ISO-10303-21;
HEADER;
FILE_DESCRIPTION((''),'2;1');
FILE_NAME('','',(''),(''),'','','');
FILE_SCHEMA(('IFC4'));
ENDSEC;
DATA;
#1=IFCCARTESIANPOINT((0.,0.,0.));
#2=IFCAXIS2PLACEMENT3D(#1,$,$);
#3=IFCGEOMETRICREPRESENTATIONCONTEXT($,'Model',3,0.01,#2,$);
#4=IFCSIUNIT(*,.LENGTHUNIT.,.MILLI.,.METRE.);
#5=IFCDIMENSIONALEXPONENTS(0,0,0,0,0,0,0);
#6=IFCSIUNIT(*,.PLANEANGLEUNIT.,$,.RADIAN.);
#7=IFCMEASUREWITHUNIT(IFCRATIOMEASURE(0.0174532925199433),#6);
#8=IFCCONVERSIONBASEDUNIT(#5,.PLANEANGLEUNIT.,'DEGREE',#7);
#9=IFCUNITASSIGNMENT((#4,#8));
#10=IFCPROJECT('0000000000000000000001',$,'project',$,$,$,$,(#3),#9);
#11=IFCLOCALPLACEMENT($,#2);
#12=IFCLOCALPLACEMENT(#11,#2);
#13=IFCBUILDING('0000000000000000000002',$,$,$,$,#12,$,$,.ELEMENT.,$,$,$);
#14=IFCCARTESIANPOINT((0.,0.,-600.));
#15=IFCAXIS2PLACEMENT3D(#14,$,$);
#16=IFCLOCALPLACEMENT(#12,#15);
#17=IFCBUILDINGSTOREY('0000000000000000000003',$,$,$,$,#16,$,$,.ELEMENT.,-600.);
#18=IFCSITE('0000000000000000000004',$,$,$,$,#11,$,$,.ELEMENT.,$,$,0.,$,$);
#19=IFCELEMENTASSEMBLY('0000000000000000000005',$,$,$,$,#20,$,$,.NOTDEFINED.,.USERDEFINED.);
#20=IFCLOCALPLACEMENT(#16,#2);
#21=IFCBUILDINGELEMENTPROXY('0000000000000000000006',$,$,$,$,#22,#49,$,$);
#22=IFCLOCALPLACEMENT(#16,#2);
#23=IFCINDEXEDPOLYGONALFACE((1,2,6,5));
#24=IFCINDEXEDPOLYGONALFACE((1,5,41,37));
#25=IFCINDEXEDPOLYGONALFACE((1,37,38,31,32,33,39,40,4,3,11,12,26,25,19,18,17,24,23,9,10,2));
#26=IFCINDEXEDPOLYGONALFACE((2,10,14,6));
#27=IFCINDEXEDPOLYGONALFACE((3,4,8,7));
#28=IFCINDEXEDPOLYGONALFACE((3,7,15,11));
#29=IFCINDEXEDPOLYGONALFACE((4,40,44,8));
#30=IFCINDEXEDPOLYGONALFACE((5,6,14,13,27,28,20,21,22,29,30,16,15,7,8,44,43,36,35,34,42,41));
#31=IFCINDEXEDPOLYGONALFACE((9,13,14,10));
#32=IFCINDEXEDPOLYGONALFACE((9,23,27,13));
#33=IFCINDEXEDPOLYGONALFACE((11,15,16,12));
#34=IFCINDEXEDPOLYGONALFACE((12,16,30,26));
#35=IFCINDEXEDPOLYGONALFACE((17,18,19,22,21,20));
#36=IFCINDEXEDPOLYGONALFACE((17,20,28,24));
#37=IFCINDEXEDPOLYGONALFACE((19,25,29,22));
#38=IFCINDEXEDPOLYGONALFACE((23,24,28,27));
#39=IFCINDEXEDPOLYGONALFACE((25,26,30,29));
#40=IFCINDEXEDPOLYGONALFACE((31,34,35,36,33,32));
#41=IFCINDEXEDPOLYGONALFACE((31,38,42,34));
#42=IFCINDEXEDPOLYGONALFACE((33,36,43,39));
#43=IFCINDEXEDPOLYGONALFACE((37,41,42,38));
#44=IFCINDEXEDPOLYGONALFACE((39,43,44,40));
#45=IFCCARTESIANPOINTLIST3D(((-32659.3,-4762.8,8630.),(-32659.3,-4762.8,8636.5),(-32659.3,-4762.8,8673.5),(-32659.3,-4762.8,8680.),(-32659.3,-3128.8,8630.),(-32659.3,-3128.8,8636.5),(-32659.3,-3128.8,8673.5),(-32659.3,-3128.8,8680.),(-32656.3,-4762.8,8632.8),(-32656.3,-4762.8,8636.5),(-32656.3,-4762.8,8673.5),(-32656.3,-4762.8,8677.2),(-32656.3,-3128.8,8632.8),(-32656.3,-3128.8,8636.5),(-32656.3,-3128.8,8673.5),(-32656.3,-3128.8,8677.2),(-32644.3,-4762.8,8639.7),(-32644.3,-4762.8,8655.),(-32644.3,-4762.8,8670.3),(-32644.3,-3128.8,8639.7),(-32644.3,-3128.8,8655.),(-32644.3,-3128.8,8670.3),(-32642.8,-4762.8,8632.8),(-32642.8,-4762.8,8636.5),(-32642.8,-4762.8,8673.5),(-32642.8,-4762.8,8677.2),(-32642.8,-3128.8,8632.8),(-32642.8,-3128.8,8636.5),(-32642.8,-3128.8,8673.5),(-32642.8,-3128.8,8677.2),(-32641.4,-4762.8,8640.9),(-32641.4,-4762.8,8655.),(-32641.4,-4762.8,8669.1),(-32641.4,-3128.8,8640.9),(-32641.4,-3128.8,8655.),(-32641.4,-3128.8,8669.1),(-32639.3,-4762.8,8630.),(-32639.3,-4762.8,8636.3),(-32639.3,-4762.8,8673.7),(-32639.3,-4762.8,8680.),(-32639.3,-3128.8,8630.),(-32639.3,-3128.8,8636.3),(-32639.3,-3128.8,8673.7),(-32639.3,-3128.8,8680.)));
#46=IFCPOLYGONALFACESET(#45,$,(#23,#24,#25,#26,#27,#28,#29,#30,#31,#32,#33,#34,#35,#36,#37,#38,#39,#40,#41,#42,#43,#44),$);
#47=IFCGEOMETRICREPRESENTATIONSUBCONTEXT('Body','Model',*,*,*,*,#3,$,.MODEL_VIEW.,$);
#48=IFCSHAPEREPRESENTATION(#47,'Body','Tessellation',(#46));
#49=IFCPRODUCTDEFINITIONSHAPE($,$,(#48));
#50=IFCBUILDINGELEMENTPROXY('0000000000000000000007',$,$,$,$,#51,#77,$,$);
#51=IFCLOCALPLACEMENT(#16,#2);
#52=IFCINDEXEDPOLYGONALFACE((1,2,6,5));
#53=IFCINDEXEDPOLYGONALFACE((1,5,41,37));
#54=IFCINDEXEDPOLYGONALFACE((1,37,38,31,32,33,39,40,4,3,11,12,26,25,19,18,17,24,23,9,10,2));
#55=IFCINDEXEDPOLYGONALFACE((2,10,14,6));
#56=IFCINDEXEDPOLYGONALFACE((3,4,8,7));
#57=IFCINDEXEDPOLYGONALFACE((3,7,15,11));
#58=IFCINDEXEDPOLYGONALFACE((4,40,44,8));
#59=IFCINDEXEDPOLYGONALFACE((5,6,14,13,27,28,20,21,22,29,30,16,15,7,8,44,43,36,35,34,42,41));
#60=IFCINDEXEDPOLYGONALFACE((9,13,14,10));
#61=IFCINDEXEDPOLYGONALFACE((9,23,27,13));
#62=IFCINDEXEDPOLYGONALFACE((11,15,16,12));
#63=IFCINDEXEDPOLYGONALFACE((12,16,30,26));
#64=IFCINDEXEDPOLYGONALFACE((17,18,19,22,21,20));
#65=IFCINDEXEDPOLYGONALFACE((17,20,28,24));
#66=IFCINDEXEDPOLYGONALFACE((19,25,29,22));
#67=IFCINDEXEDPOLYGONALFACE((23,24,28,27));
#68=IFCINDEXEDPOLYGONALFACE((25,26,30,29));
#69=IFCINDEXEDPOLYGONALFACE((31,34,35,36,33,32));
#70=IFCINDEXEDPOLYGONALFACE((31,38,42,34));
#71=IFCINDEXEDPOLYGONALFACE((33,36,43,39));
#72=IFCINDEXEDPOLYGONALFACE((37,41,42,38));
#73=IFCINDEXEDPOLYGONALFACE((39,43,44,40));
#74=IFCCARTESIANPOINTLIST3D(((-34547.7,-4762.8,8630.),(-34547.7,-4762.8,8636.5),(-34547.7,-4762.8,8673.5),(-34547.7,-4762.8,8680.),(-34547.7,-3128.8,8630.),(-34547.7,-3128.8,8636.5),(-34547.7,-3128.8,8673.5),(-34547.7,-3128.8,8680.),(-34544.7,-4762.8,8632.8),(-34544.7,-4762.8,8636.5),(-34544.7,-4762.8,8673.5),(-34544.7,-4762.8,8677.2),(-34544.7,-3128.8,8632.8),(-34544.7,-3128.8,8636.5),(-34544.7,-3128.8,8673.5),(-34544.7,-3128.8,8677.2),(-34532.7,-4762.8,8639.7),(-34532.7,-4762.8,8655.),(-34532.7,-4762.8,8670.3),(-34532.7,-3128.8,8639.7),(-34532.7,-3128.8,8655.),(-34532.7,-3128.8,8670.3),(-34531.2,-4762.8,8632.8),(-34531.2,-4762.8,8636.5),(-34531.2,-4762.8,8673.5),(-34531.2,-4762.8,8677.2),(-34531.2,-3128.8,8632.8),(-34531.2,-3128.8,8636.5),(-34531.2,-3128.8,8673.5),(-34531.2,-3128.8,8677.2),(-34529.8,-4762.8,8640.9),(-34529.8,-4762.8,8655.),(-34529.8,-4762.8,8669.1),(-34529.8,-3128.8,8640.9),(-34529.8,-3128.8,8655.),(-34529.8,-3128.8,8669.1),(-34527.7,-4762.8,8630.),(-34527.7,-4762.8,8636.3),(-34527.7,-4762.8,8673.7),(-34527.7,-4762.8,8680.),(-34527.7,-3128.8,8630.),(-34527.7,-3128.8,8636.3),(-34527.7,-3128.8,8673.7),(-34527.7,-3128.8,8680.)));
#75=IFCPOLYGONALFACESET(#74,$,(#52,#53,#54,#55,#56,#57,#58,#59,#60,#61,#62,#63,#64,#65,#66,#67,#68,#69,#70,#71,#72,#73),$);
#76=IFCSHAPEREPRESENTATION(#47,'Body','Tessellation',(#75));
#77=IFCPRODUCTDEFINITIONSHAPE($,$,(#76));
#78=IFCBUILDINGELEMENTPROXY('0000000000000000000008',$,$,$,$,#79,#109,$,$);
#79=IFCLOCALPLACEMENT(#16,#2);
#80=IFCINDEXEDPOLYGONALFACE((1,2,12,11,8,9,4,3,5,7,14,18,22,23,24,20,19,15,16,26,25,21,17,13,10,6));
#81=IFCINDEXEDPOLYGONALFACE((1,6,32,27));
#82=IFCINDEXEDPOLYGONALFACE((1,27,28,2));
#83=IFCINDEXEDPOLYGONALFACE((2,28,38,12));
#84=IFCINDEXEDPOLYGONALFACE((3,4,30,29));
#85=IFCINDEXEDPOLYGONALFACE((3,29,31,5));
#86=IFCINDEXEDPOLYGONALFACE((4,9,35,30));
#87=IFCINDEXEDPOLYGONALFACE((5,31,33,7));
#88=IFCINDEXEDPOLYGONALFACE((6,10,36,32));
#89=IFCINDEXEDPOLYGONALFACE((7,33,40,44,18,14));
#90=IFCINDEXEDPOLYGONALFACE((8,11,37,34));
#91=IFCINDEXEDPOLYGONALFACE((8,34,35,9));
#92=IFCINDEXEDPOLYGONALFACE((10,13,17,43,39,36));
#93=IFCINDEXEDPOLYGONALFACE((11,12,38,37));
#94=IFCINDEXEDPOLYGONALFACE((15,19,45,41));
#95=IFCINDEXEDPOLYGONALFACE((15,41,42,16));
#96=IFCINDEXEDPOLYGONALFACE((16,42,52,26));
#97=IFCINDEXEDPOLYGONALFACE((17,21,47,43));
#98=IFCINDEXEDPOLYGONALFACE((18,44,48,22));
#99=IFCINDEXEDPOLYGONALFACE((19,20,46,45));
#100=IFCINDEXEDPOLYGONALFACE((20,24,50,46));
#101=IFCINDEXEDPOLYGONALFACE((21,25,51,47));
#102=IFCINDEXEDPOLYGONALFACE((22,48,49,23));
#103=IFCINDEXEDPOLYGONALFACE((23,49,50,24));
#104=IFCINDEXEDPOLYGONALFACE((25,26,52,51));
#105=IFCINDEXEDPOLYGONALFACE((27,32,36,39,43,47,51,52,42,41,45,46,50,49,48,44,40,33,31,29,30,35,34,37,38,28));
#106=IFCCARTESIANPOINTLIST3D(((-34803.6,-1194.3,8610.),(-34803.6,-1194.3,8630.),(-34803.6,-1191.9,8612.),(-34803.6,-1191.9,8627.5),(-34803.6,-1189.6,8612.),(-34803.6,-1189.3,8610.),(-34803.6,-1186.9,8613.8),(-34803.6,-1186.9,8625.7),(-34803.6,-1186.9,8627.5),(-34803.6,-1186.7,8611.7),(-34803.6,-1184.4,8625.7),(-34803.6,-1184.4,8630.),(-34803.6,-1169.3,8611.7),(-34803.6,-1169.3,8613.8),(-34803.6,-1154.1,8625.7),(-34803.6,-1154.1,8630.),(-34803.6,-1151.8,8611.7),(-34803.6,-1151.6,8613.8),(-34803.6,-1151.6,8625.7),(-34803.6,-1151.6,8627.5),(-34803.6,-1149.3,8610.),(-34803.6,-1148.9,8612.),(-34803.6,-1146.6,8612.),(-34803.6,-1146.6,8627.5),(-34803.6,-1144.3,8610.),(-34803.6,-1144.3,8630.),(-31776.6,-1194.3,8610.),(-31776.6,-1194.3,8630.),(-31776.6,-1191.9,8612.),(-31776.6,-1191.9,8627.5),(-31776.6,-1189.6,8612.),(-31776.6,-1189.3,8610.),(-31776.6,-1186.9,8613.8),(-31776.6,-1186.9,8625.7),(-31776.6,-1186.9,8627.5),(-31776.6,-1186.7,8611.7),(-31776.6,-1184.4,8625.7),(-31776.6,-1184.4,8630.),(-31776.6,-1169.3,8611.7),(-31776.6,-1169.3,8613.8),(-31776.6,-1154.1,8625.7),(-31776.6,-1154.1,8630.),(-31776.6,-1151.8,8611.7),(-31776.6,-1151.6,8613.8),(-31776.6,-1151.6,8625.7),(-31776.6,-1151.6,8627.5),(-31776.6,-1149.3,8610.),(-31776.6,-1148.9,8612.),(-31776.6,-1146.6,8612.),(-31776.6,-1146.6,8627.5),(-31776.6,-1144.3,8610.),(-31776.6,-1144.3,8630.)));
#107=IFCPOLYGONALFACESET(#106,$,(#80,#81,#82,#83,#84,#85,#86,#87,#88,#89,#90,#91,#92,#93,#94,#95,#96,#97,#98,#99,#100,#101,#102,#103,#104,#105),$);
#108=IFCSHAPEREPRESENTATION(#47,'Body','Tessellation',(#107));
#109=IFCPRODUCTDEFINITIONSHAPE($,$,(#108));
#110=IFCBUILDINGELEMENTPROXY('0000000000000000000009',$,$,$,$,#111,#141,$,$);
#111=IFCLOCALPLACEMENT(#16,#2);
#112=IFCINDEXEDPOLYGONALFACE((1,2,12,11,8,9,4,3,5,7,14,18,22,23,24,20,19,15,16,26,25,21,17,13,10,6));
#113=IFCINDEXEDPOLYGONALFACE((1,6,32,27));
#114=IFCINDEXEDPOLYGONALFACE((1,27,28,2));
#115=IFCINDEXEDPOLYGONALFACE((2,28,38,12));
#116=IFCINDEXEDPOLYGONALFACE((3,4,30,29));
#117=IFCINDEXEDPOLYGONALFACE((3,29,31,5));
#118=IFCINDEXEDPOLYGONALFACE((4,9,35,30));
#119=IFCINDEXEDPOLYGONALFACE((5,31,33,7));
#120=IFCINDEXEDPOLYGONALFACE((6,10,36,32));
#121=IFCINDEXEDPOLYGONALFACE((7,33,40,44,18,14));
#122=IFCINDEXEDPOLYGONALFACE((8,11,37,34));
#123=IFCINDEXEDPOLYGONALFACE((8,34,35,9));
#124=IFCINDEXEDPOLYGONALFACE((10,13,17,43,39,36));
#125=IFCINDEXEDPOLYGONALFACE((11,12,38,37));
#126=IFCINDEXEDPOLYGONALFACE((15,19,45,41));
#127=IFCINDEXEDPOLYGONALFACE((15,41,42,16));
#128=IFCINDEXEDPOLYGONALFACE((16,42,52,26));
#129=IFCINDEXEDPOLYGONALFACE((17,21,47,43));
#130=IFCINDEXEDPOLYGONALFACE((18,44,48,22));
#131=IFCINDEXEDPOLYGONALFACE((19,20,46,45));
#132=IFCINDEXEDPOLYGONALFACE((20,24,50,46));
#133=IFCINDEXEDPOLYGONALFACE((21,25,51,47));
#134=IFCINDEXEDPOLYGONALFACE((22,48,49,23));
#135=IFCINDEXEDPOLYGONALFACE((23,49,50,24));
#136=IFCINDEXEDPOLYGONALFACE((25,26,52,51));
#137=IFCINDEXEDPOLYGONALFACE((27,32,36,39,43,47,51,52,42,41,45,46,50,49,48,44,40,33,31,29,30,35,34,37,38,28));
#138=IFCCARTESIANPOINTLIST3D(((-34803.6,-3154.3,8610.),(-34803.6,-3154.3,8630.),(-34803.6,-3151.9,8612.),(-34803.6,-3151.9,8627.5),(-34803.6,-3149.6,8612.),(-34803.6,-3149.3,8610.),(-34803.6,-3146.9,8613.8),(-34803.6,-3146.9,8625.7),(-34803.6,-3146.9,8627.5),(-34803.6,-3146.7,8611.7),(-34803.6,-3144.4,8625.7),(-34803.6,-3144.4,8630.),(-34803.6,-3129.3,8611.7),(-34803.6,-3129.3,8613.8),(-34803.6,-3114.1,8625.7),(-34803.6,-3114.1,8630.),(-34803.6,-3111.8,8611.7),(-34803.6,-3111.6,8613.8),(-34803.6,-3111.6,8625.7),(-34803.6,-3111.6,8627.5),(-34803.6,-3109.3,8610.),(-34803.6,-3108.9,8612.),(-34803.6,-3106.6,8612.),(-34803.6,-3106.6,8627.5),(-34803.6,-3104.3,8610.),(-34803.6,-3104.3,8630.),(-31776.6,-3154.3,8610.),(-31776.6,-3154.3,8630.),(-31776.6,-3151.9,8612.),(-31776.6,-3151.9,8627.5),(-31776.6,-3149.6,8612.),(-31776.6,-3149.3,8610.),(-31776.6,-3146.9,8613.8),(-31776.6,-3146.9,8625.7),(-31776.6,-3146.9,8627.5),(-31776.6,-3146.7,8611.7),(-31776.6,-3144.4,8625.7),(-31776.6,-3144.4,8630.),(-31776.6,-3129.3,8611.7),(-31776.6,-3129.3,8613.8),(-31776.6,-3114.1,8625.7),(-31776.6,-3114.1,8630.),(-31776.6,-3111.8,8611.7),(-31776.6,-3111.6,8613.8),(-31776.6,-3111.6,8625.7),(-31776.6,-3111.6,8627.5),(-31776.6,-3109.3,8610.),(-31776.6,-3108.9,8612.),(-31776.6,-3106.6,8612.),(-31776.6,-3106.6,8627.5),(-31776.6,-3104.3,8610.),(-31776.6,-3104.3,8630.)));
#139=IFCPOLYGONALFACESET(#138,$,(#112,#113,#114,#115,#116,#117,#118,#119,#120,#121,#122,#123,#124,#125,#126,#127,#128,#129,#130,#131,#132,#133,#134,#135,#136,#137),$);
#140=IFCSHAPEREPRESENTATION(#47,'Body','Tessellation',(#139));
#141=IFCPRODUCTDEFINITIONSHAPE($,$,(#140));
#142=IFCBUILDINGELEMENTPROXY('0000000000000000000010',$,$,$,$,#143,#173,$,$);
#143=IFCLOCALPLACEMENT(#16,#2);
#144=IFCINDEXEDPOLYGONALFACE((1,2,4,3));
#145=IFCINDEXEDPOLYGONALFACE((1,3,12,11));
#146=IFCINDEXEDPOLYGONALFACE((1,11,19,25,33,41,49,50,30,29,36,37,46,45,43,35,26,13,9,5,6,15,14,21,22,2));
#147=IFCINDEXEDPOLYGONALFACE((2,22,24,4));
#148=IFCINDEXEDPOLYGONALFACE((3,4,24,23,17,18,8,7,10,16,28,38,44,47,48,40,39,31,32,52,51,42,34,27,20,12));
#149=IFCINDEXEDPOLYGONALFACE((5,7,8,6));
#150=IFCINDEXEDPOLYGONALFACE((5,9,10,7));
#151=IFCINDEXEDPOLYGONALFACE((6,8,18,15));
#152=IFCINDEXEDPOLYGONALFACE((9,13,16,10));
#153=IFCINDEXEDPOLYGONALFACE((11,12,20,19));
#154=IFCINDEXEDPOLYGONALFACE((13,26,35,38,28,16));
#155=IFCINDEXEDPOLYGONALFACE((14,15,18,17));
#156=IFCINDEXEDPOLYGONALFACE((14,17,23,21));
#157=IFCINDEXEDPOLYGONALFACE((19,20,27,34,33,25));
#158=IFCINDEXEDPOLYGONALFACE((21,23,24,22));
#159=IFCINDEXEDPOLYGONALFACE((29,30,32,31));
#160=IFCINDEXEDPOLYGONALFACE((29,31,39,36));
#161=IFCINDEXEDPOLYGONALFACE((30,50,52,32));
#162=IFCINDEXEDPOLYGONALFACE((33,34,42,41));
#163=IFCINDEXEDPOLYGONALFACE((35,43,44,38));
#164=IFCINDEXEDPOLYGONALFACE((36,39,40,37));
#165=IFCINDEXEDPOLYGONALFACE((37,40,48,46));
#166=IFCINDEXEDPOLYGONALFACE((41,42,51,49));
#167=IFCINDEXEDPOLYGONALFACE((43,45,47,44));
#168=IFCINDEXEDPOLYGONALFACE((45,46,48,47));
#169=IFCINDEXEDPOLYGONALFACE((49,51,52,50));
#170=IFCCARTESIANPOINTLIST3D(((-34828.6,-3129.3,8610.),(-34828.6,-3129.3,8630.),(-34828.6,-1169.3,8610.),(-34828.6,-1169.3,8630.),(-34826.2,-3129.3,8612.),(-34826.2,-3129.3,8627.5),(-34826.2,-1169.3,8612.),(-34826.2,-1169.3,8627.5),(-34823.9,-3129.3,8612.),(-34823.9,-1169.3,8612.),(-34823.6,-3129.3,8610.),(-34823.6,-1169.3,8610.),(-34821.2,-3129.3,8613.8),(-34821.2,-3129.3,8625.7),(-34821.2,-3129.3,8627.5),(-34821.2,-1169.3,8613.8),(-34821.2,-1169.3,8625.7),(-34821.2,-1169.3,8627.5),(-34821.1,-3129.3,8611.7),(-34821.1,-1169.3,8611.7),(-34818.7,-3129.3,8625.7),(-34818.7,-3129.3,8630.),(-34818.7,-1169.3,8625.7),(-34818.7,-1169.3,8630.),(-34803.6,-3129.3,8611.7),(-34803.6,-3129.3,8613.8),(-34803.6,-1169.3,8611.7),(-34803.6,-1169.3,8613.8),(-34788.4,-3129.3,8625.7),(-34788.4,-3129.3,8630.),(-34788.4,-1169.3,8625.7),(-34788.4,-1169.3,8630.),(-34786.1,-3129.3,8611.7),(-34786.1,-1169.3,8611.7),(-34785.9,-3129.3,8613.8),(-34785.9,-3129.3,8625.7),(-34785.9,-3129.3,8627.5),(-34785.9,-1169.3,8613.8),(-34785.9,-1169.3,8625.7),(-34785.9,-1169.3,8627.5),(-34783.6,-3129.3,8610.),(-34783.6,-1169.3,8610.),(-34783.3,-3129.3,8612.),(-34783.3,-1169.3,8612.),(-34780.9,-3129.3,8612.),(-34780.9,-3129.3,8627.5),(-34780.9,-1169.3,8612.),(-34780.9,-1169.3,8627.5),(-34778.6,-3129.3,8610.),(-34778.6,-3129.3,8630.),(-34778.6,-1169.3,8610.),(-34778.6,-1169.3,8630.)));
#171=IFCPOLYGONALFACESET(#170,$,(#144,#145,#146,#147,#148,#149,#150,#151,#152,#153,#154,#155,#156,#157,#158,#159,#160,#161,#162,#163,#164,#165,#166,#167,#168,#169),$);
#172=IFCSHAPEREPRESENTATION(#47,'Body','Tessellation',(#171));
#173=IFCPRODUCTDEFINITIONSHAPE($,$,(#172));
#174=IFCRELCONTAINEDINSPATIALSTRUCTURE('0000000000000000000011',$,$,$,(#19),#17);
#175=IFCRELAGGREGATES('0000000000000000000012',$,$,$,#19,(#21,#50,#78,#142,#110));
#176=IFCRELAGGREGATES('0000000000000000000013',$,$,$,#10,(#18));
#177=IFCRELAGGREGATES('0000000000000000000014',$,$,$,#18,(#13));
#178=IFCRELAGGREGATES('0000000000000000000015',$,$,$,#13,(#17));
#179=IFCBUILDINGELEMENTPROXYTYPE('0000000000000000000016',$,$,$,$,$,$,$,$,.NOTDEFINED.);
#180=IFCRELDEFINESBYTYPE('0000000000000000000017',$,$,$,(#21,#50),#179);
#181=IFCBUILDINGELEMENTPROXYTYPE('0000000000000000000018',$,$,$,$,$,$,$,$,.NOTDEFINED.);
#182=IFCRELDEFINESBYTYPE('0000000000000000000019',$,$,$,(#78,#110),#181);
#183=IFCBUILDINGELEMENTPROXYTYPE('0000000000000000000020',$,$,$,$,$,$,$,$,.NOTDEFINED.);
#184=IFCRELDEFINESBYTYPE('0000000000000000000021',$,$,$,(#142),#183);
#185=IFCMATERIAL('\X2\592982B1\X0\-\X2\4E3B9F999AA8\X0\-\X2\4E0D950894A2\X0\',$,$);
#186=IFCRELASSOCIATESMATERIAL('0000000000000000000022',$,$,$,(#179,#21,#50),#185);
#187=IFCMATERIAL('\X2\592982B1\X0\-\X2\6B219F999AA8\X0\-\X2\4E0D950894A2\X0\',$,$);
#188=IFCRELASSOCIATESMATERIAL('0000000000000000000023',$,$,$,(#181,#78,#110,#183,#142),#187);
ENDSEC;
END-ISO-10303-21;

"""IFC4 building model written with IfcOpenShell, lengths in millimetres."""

from ifc_helpers import new_model, entity, si_unit, converted_unit, frame, origin, place, context, subcontext, project, spatial, polyline, outline, extrude, source, transform, mapped, material, type_object, type_shapes, element, aggregate, save


model = new_model("IFC4")

# Units and contexts
model_context = context("Model", 3, precision=0.01, world=origin())
body_context = subcontext(model_context, "Body", "Model", "MODEL_VIEW")
ifc_project = project(units=[si_unit("LENGTHUNIT", "METRE", prefix="MILLI"), converted_unit("PLANEANGLEUNIT", "DEGREE", entity("IfcRatioMeasure", 0.0174532925199433), si_unit("PLANEANGLEUNIT", "RADIAN"), dimensions=[0, 0, 0, 0, 0, 0, 0])], contexts=[model_context])

# Site, building, storey
site_placement = place(None, origin())
site = spatial("IfcSite", under=ifc_project, at=site_placement, CompositionType="ELEMENT", RefElevation=0.0)
building_placement = place(site_placement, origin())
building = spatial("IfcBuilding", under=site, at=building_placement, CompositionType="ELEMENT")
storey_placement = place(building_placement, frame((0.0, 0.0, -600.0)))
storey = spatial("IfcBuildingStorey", under=building, at=storey_placement, CompositionType="ELEMENT", Elevation=-600.0)

# Element assembly, building element proxies
assembly_placement = place(storey_placement, origin())
assembly = element("IfcElementAssembly", 1, at=assembly_placement, inside=storey, AssemblyPlace="NOTDEFINED", PredefinedType="USERDEFINED")
ifc_material_1 = material(Name="天花-次龙骨-不锈钢")
ifc_material_2 = material(Name="天花-主龙骨-不锈钢")
building_element_proxy_type_1 = type_object("IfcBuildingElementProxyType", PredefinedType="NOTDEFINED", material=ifc_material_2)
shared_shape_1 = source(origin(), body_context, "Body", "SweptSolid", [
    extrude(outline(polyline([(-25.0, -11.7), (-18.5, -11.7), (-18.5, -8.7), (-22.2, -8.7), (-22.2, 4.8), (-18.5, 4.8), (-15.3, 3.3), (0.0, 3.3), (15.3, 3.3), (18.5, 4.8), (22.2, 4.8), (22.2, -8.7), (18.5, -8.7), (18.5, -11.7), (25.0, -11.7), (25.0, 8.3), (18.7, 8.3), (14.1, 6.2), (0.0, 6.2), (-14.1, 6.2), (-18.7, 8.3), (-25.0, 8.3), (-25.0, -11.7)])), frame((0.0, 1.7, 0.0), z_axis=(1.0, 0.0, 0.0), x_axis=(0.0, 0.0, -1.0)), (0.0, 0.0, 1.0), 1634.0),
])
type_shapes(building_element_proxy_type_1, [shared_shape_1])
proxy_1_placement = place(assembly_placement, frame((-32649.3, -3128.8, 8655.0), z_axis=(0.0, 0.0, 1.0), x_axis=(0.0, -1.0, 0.0)))
proxy_1 = element("IfcBuildingElementProxy", 2, at=proxy_1_placement, type_object=building_element_proxy_type_1, material=ifc_material_2, context=body_context, shape_type="MappedRepresentation", body=[
    mapped(shared_shape_1, transform((0.0, 0.0, 0.0), scale=1.0)),
])
proxy_2_placement = place(assembly_placement, frame((-34537.7, -3128.8, 8655.0), z_axis=(0.0, 0.0, 1.0), x_axis=(0.0, -1.0, 0.0)))
proxy_2 = element("IfcBuildingElementProxy", 3, at=proxy_2_placement, type_object=building_element_proxy_type_1, material=ifc_material_2, context=body_context, shape_type="MappedRepresentation", body=[
    mapped(shared_shape_1, transform((0.0, 0.0, 0.0), scale=1.0)),
])
building_element_proxy_type_2 = type_object("IfcBuildingElementProxyType", PredefinedType="NOTDEFINED", material=ifc_material_1)
shared_shape_2 = source(origin(), body_context, "Body", "SweptSolid", [
    extrude(outline(polyline([(-25.0, -9.1), (-20.0, -9.1), (-17.5, -7.4), (0.0, -7.4), (17.5, -7.4), (20.0, -9.1), (25.0, -9.1), (25.0, 10.9), (15.1, 10.9), (15.1, 6.6), (17.6, 6.6), (17.6, 8.4), (22.6, 8.4), (22.6, -7.1), (20.3, -7.1), (17.6, -5.3), (0.0, -5.3), (-17.6, -5.3), (-20.3, -7.1), (-22.6, -7.1), (-22.6, 8.4), (-17.6, 8.4), (-17.6, 6.6), (-15.1, 6.6), (-15.1, 10.9), (-25.0, 10.9), (-25.0, -9.1)])), frame((0.0, 0.0, -0.9), z_axis=(1.0, 0.0, 0.0), x_axis=(0.0, 1.0, 0.0)), (0.0, 0.0, 1.0), 3027.0),
])
type_shapes(building_element_proxy_type_2, [shared_shape_2])
proxy_3_placement = place(assembly_placement, frame((-34803.6, -1169.3, 8620.0)))
proxy_3 = element("IfcBuildingElementProxy", 4, at=proxy_3_placement, type_object=building_element_proxy_type_2, material=ifc_material_1, context=body_context, shape_type="MappedRepresentation", body=[
    mapped(shared_shape_2, transform((0.0, 0.0, 0.0), scale=1.0)),
])
proxy_4_placement = place(assembly_placement, frame((-34803.6, -3129.3, 8620.0)))
proxy_4 = element("IfcBuildingElementProxy", 5, at=proxy_4_placement, type_object=building_element_proxy_type_2, material=ifc_material_1, context=body_context, shape_type="MappedRepresentation", body=[
    mapped(shared_shape_2, transform((0.0, 0.0, 0.0), scale=1.0)),
])
building_element_proxy_type_3 = type_object("IfcBuildingElementProxyType", PredefinedType="NOTDEFINED", material=ifc_material_1)
shared_shape_3 = source(origin(), body_context, "Body", "SweptSolid", [
    extrude(outline(polyline([(-25.0, -9.1), (-20.0, -9.1), (-17.5, -7.4), (0.0, -7.4), (17.5, -7.4), (20.0, -9.1), (25.0, -9.1), (25.0, 10.9), (15.1, 10.9), (15.1, 6.6), (17.6, 6.6), (17.6, 8.4), (22.6, 8.4), (22.6, -7.1), (20.3, -7.1), (17.6, -5.3), (0.0, -5.3), (-17.6, -5.3), (-20.3, -7.1), (-22.6, -7.1), (-22.6, 8.4), (-17.6, 8.4), (-17.6, 6.6), (-15.1, 6.6), (-15.1, 10.9), (-25.0, 10.9), (-25.0, -9.1)])), frame((0.0, 0.0, -0.9), z_axis=(1.0, 0.0, 0.0), x_axis=(0.0, 1.0, 0.0)), (0.0, 0.0, 1.0), 1960.0),
])
type_shapes(building_element_proxy_type_3, [shared_shape_3])
proxy_5_placement = place(assembly_placement, frame((-34803.6, -1169.3, 8620.0), z_axis=(0.0, 0.0, 1.0), x_axis=(0.0, -1.0, 0.0)))
proxy_5 = element("IfcBuildingElementProxy", 6, at=proxy_5_placement, type_object=building_element_proxy_type_3, material=ifc_material_1, context=body_context, shape_type="MappedRepresentation", body=[
    mapped(shared_shape_3, transform((0.0, 0.0, 0.0), scale=1.0)),
])
aggregate(assembly, [proxy_1, proxy_2, proxy_3, proxy_5, proxy_4])

save(model, "model.ifc")
